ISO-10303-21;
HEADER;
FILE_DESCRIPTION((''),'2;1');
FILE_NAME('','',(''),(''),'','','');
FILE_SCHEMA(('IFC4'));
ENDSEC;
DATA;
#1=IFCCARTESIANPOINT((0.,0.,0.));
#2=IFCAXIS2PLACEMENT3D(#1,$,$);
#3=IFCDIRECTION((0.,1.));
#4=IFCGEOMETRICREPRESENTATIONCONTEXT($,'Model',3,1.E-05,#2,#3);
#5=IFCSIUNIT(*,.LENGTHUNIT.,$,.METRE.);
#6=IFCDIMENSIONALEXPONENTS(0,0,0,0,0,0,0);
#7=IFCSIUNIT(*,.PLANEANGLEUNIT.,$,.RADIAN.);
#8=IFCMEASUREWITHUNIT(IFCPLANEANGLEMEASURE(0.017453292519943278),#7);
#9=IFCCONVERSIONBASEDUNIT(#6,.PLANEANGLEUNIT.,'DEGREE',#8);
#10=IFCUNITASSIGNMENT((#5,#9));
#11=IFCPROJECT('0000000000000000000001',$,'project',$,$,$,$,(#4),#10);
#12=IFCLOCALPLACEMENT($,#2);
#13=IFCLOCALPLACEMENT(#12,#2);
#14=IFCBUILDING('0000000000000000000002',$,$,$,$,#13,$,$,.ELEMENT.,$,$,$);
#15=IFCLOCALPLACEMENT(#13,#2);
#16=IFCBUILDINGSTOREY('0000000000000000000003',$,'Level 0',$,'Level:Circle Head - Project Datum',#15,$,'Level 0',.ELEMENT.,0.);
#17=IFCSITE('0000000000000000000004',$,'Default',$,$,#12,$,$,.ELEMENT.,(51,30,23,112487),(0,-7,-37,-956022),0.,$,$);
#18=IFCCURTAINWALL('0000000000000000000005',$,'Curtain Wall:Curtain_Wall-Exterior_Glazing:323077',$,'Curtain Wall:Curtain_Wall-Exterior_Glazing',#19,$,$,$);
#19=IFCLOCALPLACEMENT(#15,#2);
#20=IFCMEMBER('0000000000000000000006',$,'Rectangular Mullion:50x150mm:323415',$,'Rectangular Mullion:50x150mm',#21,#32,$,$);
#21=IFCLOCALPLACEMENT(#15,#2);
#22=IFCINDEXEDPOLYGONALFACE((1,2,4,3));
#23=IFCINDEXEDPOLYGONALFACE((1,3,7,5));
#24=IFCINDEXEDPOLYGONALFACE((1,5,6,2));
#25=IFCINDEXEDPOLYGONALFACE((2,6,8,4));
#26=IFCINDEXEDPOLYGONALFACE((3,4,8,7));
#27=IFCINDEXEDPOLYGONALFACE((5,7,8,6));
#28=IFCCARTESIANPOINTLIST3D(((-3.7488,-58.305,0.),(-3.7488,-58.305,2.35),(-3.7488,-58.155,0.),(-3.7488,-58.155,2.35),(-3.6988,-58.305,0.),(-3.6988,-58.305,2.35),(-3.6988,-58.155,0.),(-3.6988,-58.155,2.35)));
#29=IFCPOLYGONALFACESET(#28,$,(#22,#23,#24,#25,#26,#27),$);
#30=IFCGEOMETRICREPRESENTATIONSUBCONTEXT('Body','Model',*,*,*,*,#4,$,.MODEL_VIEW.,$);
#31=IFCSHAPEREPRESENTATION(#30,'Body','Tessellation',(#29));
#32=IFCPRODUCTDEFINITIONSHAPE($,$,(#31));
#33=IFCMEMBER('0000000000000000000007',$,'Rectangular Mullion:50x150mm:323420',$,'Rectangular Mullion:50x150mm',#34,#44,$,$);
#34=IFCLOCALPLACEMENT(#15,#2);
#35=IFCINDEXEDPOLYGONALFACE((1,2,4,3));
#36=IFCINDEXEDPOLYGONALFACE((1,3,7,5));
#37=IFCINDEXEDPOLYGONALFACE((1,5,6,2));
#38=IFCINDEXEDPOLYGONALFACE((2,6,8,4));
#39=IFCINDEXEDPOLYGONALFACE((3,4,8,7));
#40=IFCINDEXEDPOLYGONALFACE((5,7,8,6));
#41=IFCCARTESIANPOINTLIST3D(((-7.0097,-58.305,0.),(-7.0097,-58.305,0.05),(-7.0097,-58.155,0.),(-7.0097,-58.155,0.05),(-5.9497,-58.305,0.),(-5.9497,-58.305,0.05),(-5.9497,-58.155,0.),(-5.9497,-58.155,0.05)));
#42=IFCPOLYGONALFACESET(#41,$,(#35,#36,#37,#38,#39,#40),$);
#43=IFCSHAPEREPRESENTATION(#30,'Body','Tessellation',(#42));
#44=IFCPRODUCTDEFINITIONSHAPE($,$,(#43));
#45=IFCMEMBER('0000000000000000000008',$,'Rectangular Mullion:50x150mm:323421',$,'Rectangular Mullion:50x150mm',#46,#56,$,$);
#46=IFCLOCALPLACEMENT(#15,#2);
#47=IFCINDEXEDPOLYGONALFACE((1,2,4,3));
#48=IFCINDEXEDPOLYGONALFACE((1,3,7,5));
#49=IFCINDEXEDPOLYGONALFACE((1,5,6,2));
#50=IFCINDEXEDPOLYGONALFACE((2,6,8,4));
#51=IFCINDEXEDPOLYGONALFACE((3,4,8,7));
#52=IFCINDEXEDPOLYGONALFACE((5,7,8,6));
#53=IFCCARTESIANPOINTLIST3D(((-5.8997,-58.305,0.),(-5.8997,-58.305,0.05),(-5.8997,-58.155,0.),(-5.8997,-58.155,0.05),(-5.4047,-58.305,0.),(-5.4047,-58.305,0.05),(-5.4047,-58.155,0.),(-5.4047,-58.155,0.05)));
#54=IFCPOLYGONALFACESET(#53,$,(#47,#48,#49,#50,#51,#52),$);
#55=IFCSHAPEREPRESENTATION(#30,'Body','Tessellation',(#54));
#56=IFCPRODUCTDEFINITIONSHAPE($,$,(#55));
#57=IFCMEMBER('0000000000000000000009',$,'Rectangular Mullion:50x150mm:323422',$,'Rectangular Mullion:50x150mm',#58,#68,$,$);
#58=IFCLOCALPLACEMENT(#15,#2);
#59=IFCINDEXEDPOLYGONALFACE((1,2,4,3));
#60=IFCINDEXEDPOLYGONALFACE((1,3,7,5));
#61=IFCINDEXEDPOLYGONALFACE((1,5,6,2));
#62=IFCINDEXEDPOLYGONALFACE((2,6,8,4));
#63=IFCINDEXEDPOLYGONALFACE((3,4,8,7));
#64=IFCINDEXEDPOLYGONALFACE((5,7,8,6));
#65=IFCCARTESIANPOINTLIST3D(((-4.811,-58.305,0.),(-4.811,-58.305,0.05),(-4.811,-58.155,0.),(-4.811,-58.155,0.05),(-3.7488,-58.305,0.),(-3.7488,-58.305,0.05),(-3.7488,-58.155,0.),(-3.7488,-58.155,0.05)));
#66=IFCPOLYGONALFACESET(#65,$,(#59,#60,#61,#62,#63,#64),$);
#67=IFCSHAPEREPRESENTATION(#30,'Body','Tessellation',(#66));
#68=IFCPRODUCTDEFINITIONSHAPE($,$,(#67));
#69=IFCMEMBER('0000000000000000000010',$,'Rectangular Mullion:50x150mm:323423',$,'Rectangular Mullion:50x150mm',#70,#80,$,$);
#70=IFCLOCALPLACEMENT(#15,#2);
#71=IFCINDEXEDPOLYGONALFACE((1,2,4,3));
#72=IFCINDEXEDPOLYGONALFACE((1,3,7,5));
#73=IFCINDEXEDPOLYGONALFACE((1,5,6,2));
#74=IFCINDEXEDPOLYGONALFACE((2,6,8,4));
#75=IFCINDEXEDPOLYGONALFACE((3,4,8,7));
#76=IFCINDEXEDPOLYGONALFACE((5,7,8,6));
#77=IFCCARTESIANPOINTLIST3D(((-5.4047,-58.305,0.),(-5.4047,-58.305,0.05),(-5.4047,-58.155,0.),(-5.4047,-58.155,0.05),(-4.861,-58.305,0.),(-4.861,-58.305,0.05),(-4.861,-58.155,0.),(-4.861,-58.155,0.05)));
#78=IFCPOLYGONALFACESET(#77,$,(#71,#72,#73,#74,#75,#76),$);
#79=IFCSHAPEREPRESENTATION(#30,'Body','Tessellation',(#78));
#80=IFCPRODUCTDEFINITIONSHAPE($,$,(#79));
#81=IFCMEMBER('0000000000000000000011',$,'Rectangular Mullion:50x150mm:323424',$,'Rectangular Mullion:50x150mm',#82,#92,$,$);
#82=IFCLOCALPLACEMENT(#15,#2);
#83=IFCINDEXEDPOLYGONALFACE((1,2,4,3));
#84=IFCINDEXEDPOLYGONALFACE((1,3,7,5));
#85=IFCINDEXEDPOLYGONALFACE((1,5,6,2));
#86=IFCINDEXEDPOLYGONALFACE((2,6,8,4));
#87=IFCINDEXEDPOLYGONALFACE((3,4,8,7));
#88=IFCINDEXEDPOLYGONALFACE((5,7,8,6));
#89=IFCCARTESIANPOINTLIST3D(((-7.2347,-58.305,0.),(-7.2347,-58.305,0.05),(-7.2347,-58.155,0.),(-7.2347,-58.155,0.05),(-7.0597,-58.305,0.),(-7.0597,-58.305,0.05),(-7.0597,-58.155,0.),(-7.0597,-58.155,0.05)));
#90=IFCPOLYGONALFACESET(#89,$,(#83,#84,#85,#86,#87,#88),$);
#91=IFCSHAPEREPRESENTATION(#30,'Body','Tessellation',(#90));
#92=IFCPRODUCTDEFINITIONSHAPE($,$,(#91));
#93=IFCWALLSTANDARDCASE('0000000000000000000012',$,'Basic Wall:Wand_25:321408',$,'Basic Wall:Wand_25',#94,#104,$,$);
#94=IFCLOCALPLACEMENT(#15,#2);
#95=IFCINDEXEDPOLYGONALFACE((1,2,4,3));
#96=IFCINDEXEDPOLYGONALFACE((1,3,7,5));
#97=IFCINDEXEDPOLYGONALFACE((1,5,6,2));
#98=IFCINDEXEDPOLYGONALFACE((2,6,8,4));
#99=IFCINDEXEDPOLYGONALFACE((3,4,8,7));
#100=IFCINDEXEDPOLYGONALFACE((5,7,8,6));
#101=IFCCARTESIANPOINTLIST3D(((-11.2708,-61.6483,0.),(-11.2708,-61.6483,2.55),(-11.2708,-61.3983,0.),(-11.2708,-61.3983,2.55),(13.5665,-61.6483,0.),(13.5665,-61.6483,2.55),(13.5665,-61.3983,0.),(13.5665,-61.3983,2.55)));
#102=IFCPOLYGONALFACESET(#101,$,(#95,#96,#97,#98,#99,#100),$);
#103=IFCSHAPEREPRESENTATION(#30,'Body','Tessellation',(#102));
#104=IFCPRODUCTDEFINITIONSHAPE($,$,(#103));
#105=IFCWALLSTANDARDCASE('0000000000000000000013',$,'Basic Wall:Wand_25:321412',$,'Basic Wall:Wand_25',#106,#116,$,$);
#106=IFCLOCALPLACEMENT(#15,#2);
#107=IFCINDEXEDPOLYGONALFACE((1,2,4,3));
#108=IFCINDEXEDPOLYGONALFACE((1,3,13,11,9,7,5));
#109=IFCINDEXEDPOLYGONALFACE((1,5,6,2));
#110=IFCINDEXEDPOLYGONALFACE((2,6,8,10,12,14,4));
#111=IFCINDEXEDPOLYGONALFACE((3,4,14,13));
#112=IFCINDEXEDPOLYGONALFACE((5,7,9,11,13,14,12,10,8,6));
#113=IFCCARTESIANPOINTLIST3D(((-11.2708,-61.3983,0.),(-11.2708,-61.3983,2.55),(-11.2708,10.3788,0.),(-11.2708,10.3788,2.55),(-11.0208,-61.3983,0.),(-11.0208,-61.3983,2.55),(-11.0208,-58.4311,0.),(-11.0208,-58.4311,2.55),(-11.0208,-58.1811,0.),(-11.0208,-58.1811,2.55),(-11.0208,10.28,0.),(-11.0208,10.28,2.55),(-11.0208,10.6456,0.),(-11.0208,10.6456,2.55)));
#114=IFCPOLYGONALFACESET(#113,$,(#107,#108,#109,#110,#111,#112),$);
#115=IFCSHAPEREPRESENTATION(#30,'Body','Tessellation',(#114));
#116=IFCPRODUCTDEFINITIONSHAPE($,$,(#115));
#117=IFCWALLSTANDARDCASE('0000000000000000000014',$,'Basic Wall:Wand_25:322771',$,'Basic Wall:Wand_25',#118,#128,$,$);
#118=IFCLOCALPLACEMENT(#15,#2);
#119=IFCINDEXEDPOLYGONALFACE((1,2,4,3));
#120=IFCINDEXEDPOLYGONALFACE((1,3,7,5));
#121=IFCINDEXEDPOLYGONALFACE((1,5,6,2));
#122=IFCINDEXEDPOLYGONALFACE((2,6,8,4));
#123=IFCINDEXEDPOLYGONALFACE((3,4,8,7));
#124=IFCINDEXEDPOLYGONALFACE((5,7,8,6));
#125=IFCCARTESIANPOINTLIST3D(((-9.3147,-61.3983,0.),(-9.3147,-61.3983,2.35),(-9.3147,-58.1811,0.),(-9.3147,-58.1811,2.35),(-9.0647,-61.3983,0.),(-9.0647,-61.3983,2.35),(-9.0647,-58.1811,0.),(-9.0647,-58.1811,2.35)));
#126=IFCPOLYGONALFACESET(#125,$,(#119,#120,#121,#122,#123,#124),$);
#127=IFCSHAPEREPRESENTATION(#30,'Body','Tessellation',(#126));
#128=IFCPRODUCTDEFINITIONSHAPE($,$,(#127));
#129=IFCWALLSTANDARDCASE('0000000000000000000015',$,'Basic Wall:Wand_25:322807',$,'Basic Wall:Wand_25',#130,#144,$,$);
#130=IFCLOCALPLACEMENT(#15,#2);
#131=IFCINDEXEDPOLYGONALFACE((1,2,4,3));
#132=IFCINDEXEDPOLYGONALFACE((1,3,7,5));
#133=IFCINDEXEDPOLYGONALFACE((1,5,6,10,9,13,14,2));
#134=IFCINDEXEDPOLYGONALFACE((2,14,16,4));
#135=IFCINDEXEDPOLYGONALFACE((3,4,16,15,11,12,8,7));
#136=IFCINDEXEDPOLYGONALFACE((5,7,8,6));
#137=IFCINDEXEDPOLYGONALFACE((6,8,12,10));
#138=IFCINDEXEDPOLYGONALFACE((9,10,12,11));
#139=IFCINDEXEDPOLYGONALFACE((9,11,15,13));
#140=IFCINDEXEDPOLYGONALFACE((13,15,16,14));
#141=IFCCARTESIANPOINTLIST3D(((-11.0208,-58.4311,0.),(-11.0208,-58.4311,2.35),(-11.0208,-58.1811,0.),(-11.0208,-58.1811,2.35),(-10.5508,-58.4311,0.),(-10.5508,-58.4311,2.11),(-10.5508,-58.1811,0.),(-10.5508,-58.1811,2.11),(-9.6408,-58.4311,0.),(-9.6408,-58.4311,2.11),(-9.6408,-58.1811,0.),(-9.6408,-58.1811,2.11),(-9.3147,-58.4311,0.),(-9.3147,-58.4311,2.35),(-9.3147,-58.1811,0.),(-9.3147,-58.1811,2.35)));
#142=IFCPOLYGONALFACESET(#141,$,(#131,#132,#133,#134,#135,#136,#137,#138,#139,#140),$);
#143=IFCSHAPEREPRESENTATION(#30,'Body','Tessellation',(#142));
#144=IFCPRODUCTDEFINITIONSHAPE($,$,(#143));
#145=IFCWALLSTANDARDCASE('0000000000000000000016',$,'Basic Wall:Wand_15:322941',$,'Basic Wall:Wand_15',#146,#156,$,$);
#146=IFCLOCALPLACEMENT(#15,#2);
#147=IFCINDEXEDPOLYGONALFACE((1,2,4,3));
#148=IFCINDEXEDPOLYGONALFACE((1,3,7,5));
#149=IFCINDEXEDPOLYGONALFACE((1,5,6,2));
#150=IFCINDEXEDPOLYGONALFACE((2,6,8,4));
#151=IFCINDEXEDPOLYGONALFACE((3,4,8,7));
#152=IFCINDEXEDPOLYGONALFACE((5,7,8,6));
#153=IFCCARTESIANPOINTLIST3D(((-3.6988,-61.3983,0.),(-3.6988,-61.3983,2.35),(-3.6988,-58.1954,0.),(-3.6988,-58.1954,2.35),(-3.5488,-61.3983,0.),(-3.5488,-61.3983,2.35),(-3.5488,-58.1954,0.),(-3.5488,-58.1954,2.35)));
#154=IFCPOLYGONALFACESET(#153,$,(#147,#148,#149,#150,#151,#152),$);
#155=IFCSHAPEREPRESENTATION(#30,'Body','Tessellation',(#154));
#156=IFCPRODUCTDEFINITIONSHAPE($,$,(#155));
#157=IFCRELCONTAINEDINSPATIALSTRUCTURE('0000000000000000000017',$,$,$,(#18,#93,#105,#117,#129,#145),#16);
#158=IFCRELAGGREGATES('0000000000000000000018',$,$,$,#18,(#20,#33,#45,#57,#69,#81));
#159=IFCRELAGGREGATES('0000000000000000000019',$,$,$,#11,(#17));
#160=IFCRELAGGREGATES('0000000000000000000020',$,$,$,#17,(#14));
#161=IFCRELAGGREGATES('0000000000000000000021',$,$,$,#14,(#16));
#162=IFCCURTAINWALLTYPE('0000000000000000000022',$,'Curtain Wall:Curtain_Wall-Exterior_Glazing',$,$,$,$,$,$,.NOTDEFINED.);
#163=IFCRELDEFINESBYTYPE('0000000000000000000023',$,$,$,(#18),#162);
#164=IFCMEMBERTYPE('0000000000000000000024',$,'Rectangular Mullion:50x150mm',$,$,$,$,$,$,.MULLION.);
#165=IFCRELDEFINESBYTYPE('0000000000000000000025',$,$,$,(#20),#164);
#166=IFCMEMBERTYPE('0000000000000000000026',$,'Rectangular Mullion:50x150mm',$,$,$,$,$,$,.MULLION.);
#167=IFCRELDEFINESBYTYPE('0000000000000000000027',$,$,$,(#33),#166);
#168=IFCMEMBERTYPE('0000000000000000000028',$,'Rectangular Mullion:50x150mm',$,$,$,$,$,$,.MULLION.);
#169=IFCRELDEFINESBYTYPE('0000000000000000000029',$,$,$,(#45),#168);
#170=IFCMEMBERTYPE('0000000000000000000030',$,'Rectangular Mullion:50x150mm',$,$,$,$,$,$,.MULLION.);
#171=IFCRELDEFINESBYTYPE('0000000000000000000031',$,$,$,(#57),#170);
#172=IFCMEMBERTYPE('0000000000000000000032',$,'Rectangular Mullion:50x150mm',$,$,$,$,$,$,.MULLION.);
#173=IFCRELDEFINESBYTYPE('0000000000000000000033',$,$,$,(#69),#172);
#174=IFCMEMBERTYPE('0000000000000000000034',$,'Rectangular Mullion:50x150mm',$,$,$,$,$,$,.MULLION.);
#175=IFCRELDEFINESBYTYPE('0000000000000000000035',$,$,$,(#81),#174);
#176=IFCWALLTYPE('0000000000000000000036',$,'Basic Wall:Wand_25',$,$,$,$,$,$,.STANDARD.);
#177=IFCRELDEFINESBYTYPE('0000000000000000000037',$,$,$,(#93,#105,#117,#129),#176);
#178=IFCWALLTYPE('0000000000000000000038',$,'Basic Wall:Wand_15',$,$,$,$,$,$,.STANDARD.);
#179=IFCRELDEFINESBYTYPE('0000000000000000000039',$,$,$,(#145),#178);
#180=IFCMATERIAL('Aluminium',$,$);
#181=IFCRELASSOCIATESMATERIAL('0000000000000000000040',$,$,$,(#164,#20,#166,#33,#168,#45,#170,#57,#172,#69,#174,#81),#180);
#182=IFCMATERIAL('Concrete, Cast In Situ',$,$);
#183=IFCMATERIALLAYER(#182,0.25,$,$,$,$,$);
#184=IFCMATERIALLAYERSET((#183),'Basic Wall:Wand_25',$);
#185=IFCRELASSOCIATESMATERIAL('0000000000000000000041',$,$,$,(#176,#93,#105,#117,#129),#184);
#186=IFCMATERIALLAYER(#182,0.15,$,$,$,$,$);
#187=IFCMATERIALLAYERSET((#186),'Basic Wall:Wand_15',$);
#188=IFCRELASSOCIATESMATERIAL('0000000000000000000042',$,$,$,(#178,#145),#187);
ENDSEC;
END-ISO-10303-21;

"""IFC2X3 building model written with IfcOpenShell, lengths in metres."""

from ifc_helpers import new_model, entity, si_unit, converted_unit, direction, frame, frame_2d, origin, origin_2d_with_axis, place, context, subcontext, project, spatial, polyline, rectangle, outline, extrude, source, transform, mapped, material, layer, layer_set, layer_usage, type_object, type_shapes, element, aggregate, save


model = new_model("IFC2X3")

# Units and contexts
model_context = context("Model", 3, precision=1e-05, world=origin(), true_north=direction((0.0, 1.0)))
body_context = subcontext(model_context, "Body", "Model", "MODEL_VIEW")
ifc_project = project(units=[si_unit("LENGTHUNIT", "METRE"), converted_unit("PLANEANGLEUNIT", "DEGREE", entity("IfcPlaneAngleMeasure", 0.017453292519943278), si_unit("PLANEANGLEUNIT", "RADIAN"), dimensions=[0, 0, 0, 0, 0, 0, 0])], contexts=[model_context])

# Site, building, storey
site_placement = place(None, origin())
site = spatial("IfcSite", under=ifc_project, at=site_placement, Name="Default", CompositionType="ELEMENT", RefLatitude=(51, 30, 23, 112487), RefLongitude=(0, -7, -37, -956022), RefElevation=0.0)
building_placement = place(site_placement, origin())
building = spatial("IfcBuilding", under=site, at=building_placement, CompositionType="ELEMENT")
storey_placement = place(building_placement, origin())
storey = spatial("IfcBuildingStorey", under=building, at=storey_placement, Name="Level 0", ObjectType="Level:Circle Head - Project Datum", LongName="Level 0", CompositionType="ELEMENT", Elevation=0.0)

# Curtain wall, members
curtain_wall_type = type_object("IfcCurtainWallType", Name="Curtain Wall:Curtain_Wall-Exterior_Glazing", PredefinedType="NOTDEFINED")
curtain_wall_placement = place(storey_placement, origin())
curtain_wall = element("IfcCurtainWall", 1, at=curtain_wall_placement, inside=storey, type_object=curtain_wall_type, Name="Curtain Wall:Curtain_Wall-Exterior_Glazing:323077", ObjectType="Curtain Wall:Curtain_Wall-Exterior_Glazing")
ifc_material_1 = material(Name="Aluminium")
member_type_1 = type_object("IfcMemberType", Name="Rectangular Mullion:50x150mm", PredefinedType="MULLION", material=ifc_material_1)
shared_shape_1 = source(origin(), body_context, "Body", "SweptSolid", [
    extrude(rectangle(XDim=0.05, YDim=0.15, at=origin_2d_with_axis()), frame((-0.025, 0.0, -2.35), z_axis=(0.0, 0.0, 1.0), x_axis=(-1.0, 0.0, 0.0)), (0.0, 0.0, 1.0), 2.35),
])
type_shapes(member_type_1, [shared_shape_1])
member_1_placement = place(curtain_wall_placement, frame((-3.6988, -58.23, 0.0), z_axis=(0.0, 0.0, -1.0), x_axis=(1.0, 0.0, 0.0)))
member_1 = element("IfcMember", 2, at=member_1_placement, type_object=member_type_1, material=ifc_material_1, Name="Rectangular Mullion:50x150mm:323415", ObjectType="Rectangular Mullion:50x150mm", context=body_context, shape_type="MappedRepresentation", body=[
    mapped(shared_shape_1, transform((0.0, 0.0, 0.0), scale=1.0)),
])
member_type_2 = type_object("IfcMemberType", Name="Rectangular Mullion:50x150mm", PredefinedType="MULLION", material=ifc_material_1)
shared_shape_2 = source(origin(), body_context, "Body", "SweptSolid", [
    extrude(rectangle(XDim=0.05, YDim=0.15, at=origin_2d_with_axis()), frame((-0.025, 0.0, -1.06), z_axis=(0.0, 0.0, 1.0), x_axis=(-1.0, 0.0, 0.0)), (0.0, 0.0, 1.0), 1.06),
])
type_shapes(member_type_2, [shared_shape_2])
member_2_placement = place(curtain_wall_placement, frame((-7.0097, -58.23, 0.0), z_axis=(-1.0, 0.0, 0.0), x_axis=(0.0, 0.0, -1.0)))
member_2 = element("IfcMember", 3, at=member_2_placement, type_object=member_type_2, material=ifc_material_1, Name="Rectangular Mullion:50x150mm:323420", ObjectType="Rectangular Mullion:50x150mm", context=body_context, shape_type="MappedRepresentation", body=[
    mapped(shared_shape_2, transform((0.0, 0.0, 0.0), scale=1.0)),
])
member_type_3 = type_object("IfcMemberType", Name="Rectangular Mullion:50x150mm", PredefinedType="MULLION", material=ifc_material_1)
shared_shape_3 = source(origin(), body_context, "Body", "SweptSolid", [
    extrude(rectangle(XDim=0.05, YDim=0.15, at=origin_2d_with_axis()), frame((-0.025, 0.0, -0.495), z_axis=(0.0, 0.0, 1.0), x_axis=(-1.0, 0.0, 0.0)), (0.0, 0.0, 1.0), 0.495),
])
type_shapes(member_type_3, [shared_shape_3])
member_3_placement = place(curtain_wall_placement, frame((-5.8997, -58.23, 0.0), z_axis=(-1.0, 0.0, 0.0), x_axis=(0.0, 0.0, -1.0)))
member_3 = element("IfcMember", 4, at=member_3_placement, type_object=member_type_3, material=ifc_material_1, Name="Rectangular Mullion:50x150mm:323421", ObjectType="Rectangular Mullion:50x150mm", context=body_context, shape_type="MappedRepresentation", body=[
    mapped(shared_shape_3, transform((0.0, 0.0, 0.0), scale=1.0)),
])
member_type_4 = type_object("IfcMemberType", Name="Rectangular Mullion:50x150mm", PredefinedType="MULLION", material=ifc_material_1)
shared_shape_4 = source(origin(), body_context, "Body", "SweptSolid", [
    extrude(rectangle(XDim=0.05, YDim=0.15, at=origin_2d_with_axis()), frame((-0.025, 0.0, -1.0623), z_axis=(0.0, 0.0, 1.0), x_axis=(-1.0, 0.0, 0.0)), (0.0, 0.0, 1.0), 1.0623),
])
type_shapes(member_type_4, [shared_shape_4])
member_4_placement = place(curtain_wall_placement, frame((-4.811, -58.23, 0.0), z_axis=(-1.0, 0.0, 0.0), x_axis=(0.0, 0.0, -1.0)))
member_4 = element("IfcMember", 5, at=member_4_placement, type_object=member_type_4, material=ifc_material_1, Name="Rectangular Mullion:50x150mm:323422", ObjectType="Rectangular Mullion:50x150mm", context=body_context, shape_type="MappedRepresentation", body=[
    mapped(shared_shape_4, transform((0.0, 0.0, 0.0), scale=1.0)),
])
member_type_5 = type_object("IfcMemberType", Name="Rectangular Mullion:50x150mm", PredefinedType="MULLION", material=ifc_material_1)
shared_shape_5 = source(origin(), body_context, "Body", "SweptSolid", [
    extrude(rectangle(XDim=0.05, YDim=0.15, at=origin_2d_with_axis()), frame((-0.025, 0.0, -0.5436), z_axis=(0.0, 0.0, 1.0), x_axis=(-1.0, 0.0, 0.0)), (0.0, 0.0, 1.0), 0.5436),
])
type_shapes(member_type_5, [shared_shape_5])
member_5_placement = place(curtain_wall_placement, frame((-5.4047, -58.23, 0.0), z_axis=(-1.0, 0.0, 0.0), x_axis=(0.0, 0.0, -1.0)))
member_5 = element("IfcMember", 6, at=member_5_placement, type_object=member_type_5, material=ifc_material_1, Name="Rectangular Mullion:50x150mm:323423", ObjectType="Rectangular Mullion:50x150mm", context=body_context, shape_type="MappedRepresentation", body=[
    mapped(shared_shape_5, transform((0.0, 0.0, 0.0), scale=1.0)),
])
member_type_6 = type_object("IfcMemberType", Name="Rectangular Mullion:50x150mm", PredefinedType="MULLION", material=ifc_material_1)
shared_shape_6 = source(origin(), body_context, "Body", "SweptSolid", [
    extrude(rectangle(XDim=0.05, YDim=0.15, at=origin_2d_with_axis()), frame((-0.025, 0.0, -0.175), z_axis=(0.0, 0.0, 1.0), x_axis=(-1.0, 0.0, 0.0)), (0.0, 0.0, 1.0), 0.175),
])
type_shapes(member_type_6, [shared_shape_6])
member_6_placement = place(curtain_wall_placement, frame((-7.2347, -58.23, 0.0), z_axis=(-1.0, 0.0, 0.0), x_axis=(0.0, 0.0, -1.0)))
member_6 = element("IfcMember", 7, at=member_6_placement, type_object=member_type_6, material=ifc_material_1, Name="Rectangular Mullion:50x150mm:323424", ObjectType="Rectangular Mullion:50x150mm", context=body_context, shape_type="MappedRepresentation", body=[
    mapped(shared_shape_6, transform((0.0, 0.0, 0.0), scale=1.0)),
])
aggregate(curtain_wall, [member_1, member_2, member_3, member_4, member_5, member_6])

# Walls
ifc_material_2 = material(Name="Concrete, Cast In Situ")
ifc_layer_1 = layer(ifc_material_2, 0.25)
ifc_layer_set_1 = layer_set([ifc_layer_1], Name="Basic Wall:Wand_25")
ifc_layer_usage_1 = layer_usage(ifc_layer_set_1, "AXIS2", "NEGATIVE", 0.125)
wall_type_1 = type_object("IfcWallType", Name="Basic Wall:Wand_25", PredefinedType="STANDARD", material=ifc_layer_set_1)
wall_1_placement = place(storey_placement, frame((13.5665, -61.5233, 0.0), z_axis=(0.0, 0.0, 1.0), x_axis=(-1.0, 0.0, 0.0)))
element("IfcWallStandardCase", 8, at=wall_1_placement, inside=storey, type_object=wall_type_1, material=ifc_layer_usage_1, Name="Basic Wall:Wand_25:321408", ObjectType="Basic Wall:Wand_25", context=body_context, shape_type="SweptSolid", body=[
    extrude(rectangle(XDim=24.8373, YDim=0.25, at=frame_2d((12.4187, 0.0), x_axis=(-1.0, 0.0))), origin(), (0.0, 0.0, 1.0), 2.55),
])
wall_2_placement = place(storey_placement, frame((-11.1458, -61.3983, 0.0), z_axis=(0.0, 0.0, 1.0), x_axis=(0.0, 1.0, 0.0)))
element("IfcWallStandardCase", 9, at=wall_2_placement, inside=storey, type_object=wall_type_1, material=ifc_layer_usage_1, Name="Basic Wall:Wand_25:321412", ObjectType="Basic Wall:Wand_25", context=body_context, shape_type="SweptSolid", body=[
    extrude(outline(polyline([(72.044, -0.125), (71.7772, 0.125), (0.0, 0.125), (0.0, -0.125), (2.9672, -0.125), (3.2172, -0.125), (71.6784, -0.125), (72.044, -0.125)])), origin(), (0.0, 0.0, 1.0), 2.55),
])
wall_3_placement = place(storey_placement, frame((-9.1897, -61.3983, 0.0), z_axis=(0.0, 0.0, 1.0), x_axis=(0.0, 1.0, 0.0)))
element("IfcWallStandardCase", 10, at=wall_3_placement, inside=storey, type_object=wall_type_1, material=ifc_layer_usage_1, Name="Basic Wall:Wand_25:322771", ObjectType="Basic Wall:Wand_25", context=body_context, shape_type="SweptSolid", body=[
    extrude(rectangle(XDim=3.2172, YDim=0.25, at=frame_2d((1.6086, 0.0), x_axis=(-1.0, 0.0))), origin(), (0.0, 0.0, 1.0), 2.35),
])

# Wall, opening
wall_4_placement = place(storey_placement, frame((-9.3147, -58.3061, 0.0), z_axis=(0.0, 0.0, 1.0), x_axis=(-1.0, 0.0, 0.0)))
wall_4 = element("IfcWallStandardCase", 11, at=wall_4_placement, inside=storey, type_object=wall_type_1, material=ifc_layer_usage_1, Name="Basic Wall:Wand_25:322807", ObjectType="Basic Wall:Wand_25", context=body_context, shape_type="SweptSolid", body=[
    extrude(rectangle(XDim=1.7062, YDim=0.25, at=frame_2d((0.8531, 0.0), x_axis=(1.0, 0.0))), origin(), (0.0, 0.0, 1.0), 2.35),
])
opening_placement = place(wall_4_placement, frame((1.2362, 0.125, 0.0)))
element("IfcOpeningElement", 12, at=opening_placement, cuts=wall_4, ObjectType="Opening", context=body_context, shape_type="SweptSolid", body=[
    extrude(rectangle(XDim=2.11, YDim=0.91, at=frame_2d((1.055, 0.455), x_axis=(1.0, 0.0))), frame((0.0, 0.0, 0.0), z_axis=(0.0, -1.0, 0.0), x_axis=(0.0, 0.0, 1.0)), (0.0, 0.0, 1.0), 0.25),
])

# Wall
ifc_layer_2 = layer(ifc_material_2, 0.15)
ifc_layer_set_2 = layer_set([ifc_layer_2], Name="Basic Wall:Wand_15")
ifc_layer_usage_2 = layer_usage(ifc_layer_set_2, "AXIS2", "NEGATIVE", 0.075)
wall_type_2 = type_object("IfcWallType", Name="Basic Wall:Wand_15", PredefinedType="STANDARD", material=ifc_layer_set_2)
wall_5_placement = place(storey_placement, frame((-3.6238, -61.3983, 0.0), z_axis=(0.0, 0.0, 1.0), x_axis=(0.0, 1.0, 0.0)))
element("IfcWallStandardCase", 13, at=wall_5_placement, inside=storey, type_object=wall_type_2, material=ifc_layer_usage_2, Name="Basic Wall:Wand_15:322941", ObjectType="Basic Wall:Wand_15", context=body_context, shape_type="SweptSolid", body=[
    extrude(rectangle(XDim=3.2029, YDim=0.15, at=frame_2d((1.6015, 0.0), x_axis=(-1.0, 0.0))), origin(), (0.0, 0.0, 1.0), 2.35),
])

save(model, "model.ifc")
